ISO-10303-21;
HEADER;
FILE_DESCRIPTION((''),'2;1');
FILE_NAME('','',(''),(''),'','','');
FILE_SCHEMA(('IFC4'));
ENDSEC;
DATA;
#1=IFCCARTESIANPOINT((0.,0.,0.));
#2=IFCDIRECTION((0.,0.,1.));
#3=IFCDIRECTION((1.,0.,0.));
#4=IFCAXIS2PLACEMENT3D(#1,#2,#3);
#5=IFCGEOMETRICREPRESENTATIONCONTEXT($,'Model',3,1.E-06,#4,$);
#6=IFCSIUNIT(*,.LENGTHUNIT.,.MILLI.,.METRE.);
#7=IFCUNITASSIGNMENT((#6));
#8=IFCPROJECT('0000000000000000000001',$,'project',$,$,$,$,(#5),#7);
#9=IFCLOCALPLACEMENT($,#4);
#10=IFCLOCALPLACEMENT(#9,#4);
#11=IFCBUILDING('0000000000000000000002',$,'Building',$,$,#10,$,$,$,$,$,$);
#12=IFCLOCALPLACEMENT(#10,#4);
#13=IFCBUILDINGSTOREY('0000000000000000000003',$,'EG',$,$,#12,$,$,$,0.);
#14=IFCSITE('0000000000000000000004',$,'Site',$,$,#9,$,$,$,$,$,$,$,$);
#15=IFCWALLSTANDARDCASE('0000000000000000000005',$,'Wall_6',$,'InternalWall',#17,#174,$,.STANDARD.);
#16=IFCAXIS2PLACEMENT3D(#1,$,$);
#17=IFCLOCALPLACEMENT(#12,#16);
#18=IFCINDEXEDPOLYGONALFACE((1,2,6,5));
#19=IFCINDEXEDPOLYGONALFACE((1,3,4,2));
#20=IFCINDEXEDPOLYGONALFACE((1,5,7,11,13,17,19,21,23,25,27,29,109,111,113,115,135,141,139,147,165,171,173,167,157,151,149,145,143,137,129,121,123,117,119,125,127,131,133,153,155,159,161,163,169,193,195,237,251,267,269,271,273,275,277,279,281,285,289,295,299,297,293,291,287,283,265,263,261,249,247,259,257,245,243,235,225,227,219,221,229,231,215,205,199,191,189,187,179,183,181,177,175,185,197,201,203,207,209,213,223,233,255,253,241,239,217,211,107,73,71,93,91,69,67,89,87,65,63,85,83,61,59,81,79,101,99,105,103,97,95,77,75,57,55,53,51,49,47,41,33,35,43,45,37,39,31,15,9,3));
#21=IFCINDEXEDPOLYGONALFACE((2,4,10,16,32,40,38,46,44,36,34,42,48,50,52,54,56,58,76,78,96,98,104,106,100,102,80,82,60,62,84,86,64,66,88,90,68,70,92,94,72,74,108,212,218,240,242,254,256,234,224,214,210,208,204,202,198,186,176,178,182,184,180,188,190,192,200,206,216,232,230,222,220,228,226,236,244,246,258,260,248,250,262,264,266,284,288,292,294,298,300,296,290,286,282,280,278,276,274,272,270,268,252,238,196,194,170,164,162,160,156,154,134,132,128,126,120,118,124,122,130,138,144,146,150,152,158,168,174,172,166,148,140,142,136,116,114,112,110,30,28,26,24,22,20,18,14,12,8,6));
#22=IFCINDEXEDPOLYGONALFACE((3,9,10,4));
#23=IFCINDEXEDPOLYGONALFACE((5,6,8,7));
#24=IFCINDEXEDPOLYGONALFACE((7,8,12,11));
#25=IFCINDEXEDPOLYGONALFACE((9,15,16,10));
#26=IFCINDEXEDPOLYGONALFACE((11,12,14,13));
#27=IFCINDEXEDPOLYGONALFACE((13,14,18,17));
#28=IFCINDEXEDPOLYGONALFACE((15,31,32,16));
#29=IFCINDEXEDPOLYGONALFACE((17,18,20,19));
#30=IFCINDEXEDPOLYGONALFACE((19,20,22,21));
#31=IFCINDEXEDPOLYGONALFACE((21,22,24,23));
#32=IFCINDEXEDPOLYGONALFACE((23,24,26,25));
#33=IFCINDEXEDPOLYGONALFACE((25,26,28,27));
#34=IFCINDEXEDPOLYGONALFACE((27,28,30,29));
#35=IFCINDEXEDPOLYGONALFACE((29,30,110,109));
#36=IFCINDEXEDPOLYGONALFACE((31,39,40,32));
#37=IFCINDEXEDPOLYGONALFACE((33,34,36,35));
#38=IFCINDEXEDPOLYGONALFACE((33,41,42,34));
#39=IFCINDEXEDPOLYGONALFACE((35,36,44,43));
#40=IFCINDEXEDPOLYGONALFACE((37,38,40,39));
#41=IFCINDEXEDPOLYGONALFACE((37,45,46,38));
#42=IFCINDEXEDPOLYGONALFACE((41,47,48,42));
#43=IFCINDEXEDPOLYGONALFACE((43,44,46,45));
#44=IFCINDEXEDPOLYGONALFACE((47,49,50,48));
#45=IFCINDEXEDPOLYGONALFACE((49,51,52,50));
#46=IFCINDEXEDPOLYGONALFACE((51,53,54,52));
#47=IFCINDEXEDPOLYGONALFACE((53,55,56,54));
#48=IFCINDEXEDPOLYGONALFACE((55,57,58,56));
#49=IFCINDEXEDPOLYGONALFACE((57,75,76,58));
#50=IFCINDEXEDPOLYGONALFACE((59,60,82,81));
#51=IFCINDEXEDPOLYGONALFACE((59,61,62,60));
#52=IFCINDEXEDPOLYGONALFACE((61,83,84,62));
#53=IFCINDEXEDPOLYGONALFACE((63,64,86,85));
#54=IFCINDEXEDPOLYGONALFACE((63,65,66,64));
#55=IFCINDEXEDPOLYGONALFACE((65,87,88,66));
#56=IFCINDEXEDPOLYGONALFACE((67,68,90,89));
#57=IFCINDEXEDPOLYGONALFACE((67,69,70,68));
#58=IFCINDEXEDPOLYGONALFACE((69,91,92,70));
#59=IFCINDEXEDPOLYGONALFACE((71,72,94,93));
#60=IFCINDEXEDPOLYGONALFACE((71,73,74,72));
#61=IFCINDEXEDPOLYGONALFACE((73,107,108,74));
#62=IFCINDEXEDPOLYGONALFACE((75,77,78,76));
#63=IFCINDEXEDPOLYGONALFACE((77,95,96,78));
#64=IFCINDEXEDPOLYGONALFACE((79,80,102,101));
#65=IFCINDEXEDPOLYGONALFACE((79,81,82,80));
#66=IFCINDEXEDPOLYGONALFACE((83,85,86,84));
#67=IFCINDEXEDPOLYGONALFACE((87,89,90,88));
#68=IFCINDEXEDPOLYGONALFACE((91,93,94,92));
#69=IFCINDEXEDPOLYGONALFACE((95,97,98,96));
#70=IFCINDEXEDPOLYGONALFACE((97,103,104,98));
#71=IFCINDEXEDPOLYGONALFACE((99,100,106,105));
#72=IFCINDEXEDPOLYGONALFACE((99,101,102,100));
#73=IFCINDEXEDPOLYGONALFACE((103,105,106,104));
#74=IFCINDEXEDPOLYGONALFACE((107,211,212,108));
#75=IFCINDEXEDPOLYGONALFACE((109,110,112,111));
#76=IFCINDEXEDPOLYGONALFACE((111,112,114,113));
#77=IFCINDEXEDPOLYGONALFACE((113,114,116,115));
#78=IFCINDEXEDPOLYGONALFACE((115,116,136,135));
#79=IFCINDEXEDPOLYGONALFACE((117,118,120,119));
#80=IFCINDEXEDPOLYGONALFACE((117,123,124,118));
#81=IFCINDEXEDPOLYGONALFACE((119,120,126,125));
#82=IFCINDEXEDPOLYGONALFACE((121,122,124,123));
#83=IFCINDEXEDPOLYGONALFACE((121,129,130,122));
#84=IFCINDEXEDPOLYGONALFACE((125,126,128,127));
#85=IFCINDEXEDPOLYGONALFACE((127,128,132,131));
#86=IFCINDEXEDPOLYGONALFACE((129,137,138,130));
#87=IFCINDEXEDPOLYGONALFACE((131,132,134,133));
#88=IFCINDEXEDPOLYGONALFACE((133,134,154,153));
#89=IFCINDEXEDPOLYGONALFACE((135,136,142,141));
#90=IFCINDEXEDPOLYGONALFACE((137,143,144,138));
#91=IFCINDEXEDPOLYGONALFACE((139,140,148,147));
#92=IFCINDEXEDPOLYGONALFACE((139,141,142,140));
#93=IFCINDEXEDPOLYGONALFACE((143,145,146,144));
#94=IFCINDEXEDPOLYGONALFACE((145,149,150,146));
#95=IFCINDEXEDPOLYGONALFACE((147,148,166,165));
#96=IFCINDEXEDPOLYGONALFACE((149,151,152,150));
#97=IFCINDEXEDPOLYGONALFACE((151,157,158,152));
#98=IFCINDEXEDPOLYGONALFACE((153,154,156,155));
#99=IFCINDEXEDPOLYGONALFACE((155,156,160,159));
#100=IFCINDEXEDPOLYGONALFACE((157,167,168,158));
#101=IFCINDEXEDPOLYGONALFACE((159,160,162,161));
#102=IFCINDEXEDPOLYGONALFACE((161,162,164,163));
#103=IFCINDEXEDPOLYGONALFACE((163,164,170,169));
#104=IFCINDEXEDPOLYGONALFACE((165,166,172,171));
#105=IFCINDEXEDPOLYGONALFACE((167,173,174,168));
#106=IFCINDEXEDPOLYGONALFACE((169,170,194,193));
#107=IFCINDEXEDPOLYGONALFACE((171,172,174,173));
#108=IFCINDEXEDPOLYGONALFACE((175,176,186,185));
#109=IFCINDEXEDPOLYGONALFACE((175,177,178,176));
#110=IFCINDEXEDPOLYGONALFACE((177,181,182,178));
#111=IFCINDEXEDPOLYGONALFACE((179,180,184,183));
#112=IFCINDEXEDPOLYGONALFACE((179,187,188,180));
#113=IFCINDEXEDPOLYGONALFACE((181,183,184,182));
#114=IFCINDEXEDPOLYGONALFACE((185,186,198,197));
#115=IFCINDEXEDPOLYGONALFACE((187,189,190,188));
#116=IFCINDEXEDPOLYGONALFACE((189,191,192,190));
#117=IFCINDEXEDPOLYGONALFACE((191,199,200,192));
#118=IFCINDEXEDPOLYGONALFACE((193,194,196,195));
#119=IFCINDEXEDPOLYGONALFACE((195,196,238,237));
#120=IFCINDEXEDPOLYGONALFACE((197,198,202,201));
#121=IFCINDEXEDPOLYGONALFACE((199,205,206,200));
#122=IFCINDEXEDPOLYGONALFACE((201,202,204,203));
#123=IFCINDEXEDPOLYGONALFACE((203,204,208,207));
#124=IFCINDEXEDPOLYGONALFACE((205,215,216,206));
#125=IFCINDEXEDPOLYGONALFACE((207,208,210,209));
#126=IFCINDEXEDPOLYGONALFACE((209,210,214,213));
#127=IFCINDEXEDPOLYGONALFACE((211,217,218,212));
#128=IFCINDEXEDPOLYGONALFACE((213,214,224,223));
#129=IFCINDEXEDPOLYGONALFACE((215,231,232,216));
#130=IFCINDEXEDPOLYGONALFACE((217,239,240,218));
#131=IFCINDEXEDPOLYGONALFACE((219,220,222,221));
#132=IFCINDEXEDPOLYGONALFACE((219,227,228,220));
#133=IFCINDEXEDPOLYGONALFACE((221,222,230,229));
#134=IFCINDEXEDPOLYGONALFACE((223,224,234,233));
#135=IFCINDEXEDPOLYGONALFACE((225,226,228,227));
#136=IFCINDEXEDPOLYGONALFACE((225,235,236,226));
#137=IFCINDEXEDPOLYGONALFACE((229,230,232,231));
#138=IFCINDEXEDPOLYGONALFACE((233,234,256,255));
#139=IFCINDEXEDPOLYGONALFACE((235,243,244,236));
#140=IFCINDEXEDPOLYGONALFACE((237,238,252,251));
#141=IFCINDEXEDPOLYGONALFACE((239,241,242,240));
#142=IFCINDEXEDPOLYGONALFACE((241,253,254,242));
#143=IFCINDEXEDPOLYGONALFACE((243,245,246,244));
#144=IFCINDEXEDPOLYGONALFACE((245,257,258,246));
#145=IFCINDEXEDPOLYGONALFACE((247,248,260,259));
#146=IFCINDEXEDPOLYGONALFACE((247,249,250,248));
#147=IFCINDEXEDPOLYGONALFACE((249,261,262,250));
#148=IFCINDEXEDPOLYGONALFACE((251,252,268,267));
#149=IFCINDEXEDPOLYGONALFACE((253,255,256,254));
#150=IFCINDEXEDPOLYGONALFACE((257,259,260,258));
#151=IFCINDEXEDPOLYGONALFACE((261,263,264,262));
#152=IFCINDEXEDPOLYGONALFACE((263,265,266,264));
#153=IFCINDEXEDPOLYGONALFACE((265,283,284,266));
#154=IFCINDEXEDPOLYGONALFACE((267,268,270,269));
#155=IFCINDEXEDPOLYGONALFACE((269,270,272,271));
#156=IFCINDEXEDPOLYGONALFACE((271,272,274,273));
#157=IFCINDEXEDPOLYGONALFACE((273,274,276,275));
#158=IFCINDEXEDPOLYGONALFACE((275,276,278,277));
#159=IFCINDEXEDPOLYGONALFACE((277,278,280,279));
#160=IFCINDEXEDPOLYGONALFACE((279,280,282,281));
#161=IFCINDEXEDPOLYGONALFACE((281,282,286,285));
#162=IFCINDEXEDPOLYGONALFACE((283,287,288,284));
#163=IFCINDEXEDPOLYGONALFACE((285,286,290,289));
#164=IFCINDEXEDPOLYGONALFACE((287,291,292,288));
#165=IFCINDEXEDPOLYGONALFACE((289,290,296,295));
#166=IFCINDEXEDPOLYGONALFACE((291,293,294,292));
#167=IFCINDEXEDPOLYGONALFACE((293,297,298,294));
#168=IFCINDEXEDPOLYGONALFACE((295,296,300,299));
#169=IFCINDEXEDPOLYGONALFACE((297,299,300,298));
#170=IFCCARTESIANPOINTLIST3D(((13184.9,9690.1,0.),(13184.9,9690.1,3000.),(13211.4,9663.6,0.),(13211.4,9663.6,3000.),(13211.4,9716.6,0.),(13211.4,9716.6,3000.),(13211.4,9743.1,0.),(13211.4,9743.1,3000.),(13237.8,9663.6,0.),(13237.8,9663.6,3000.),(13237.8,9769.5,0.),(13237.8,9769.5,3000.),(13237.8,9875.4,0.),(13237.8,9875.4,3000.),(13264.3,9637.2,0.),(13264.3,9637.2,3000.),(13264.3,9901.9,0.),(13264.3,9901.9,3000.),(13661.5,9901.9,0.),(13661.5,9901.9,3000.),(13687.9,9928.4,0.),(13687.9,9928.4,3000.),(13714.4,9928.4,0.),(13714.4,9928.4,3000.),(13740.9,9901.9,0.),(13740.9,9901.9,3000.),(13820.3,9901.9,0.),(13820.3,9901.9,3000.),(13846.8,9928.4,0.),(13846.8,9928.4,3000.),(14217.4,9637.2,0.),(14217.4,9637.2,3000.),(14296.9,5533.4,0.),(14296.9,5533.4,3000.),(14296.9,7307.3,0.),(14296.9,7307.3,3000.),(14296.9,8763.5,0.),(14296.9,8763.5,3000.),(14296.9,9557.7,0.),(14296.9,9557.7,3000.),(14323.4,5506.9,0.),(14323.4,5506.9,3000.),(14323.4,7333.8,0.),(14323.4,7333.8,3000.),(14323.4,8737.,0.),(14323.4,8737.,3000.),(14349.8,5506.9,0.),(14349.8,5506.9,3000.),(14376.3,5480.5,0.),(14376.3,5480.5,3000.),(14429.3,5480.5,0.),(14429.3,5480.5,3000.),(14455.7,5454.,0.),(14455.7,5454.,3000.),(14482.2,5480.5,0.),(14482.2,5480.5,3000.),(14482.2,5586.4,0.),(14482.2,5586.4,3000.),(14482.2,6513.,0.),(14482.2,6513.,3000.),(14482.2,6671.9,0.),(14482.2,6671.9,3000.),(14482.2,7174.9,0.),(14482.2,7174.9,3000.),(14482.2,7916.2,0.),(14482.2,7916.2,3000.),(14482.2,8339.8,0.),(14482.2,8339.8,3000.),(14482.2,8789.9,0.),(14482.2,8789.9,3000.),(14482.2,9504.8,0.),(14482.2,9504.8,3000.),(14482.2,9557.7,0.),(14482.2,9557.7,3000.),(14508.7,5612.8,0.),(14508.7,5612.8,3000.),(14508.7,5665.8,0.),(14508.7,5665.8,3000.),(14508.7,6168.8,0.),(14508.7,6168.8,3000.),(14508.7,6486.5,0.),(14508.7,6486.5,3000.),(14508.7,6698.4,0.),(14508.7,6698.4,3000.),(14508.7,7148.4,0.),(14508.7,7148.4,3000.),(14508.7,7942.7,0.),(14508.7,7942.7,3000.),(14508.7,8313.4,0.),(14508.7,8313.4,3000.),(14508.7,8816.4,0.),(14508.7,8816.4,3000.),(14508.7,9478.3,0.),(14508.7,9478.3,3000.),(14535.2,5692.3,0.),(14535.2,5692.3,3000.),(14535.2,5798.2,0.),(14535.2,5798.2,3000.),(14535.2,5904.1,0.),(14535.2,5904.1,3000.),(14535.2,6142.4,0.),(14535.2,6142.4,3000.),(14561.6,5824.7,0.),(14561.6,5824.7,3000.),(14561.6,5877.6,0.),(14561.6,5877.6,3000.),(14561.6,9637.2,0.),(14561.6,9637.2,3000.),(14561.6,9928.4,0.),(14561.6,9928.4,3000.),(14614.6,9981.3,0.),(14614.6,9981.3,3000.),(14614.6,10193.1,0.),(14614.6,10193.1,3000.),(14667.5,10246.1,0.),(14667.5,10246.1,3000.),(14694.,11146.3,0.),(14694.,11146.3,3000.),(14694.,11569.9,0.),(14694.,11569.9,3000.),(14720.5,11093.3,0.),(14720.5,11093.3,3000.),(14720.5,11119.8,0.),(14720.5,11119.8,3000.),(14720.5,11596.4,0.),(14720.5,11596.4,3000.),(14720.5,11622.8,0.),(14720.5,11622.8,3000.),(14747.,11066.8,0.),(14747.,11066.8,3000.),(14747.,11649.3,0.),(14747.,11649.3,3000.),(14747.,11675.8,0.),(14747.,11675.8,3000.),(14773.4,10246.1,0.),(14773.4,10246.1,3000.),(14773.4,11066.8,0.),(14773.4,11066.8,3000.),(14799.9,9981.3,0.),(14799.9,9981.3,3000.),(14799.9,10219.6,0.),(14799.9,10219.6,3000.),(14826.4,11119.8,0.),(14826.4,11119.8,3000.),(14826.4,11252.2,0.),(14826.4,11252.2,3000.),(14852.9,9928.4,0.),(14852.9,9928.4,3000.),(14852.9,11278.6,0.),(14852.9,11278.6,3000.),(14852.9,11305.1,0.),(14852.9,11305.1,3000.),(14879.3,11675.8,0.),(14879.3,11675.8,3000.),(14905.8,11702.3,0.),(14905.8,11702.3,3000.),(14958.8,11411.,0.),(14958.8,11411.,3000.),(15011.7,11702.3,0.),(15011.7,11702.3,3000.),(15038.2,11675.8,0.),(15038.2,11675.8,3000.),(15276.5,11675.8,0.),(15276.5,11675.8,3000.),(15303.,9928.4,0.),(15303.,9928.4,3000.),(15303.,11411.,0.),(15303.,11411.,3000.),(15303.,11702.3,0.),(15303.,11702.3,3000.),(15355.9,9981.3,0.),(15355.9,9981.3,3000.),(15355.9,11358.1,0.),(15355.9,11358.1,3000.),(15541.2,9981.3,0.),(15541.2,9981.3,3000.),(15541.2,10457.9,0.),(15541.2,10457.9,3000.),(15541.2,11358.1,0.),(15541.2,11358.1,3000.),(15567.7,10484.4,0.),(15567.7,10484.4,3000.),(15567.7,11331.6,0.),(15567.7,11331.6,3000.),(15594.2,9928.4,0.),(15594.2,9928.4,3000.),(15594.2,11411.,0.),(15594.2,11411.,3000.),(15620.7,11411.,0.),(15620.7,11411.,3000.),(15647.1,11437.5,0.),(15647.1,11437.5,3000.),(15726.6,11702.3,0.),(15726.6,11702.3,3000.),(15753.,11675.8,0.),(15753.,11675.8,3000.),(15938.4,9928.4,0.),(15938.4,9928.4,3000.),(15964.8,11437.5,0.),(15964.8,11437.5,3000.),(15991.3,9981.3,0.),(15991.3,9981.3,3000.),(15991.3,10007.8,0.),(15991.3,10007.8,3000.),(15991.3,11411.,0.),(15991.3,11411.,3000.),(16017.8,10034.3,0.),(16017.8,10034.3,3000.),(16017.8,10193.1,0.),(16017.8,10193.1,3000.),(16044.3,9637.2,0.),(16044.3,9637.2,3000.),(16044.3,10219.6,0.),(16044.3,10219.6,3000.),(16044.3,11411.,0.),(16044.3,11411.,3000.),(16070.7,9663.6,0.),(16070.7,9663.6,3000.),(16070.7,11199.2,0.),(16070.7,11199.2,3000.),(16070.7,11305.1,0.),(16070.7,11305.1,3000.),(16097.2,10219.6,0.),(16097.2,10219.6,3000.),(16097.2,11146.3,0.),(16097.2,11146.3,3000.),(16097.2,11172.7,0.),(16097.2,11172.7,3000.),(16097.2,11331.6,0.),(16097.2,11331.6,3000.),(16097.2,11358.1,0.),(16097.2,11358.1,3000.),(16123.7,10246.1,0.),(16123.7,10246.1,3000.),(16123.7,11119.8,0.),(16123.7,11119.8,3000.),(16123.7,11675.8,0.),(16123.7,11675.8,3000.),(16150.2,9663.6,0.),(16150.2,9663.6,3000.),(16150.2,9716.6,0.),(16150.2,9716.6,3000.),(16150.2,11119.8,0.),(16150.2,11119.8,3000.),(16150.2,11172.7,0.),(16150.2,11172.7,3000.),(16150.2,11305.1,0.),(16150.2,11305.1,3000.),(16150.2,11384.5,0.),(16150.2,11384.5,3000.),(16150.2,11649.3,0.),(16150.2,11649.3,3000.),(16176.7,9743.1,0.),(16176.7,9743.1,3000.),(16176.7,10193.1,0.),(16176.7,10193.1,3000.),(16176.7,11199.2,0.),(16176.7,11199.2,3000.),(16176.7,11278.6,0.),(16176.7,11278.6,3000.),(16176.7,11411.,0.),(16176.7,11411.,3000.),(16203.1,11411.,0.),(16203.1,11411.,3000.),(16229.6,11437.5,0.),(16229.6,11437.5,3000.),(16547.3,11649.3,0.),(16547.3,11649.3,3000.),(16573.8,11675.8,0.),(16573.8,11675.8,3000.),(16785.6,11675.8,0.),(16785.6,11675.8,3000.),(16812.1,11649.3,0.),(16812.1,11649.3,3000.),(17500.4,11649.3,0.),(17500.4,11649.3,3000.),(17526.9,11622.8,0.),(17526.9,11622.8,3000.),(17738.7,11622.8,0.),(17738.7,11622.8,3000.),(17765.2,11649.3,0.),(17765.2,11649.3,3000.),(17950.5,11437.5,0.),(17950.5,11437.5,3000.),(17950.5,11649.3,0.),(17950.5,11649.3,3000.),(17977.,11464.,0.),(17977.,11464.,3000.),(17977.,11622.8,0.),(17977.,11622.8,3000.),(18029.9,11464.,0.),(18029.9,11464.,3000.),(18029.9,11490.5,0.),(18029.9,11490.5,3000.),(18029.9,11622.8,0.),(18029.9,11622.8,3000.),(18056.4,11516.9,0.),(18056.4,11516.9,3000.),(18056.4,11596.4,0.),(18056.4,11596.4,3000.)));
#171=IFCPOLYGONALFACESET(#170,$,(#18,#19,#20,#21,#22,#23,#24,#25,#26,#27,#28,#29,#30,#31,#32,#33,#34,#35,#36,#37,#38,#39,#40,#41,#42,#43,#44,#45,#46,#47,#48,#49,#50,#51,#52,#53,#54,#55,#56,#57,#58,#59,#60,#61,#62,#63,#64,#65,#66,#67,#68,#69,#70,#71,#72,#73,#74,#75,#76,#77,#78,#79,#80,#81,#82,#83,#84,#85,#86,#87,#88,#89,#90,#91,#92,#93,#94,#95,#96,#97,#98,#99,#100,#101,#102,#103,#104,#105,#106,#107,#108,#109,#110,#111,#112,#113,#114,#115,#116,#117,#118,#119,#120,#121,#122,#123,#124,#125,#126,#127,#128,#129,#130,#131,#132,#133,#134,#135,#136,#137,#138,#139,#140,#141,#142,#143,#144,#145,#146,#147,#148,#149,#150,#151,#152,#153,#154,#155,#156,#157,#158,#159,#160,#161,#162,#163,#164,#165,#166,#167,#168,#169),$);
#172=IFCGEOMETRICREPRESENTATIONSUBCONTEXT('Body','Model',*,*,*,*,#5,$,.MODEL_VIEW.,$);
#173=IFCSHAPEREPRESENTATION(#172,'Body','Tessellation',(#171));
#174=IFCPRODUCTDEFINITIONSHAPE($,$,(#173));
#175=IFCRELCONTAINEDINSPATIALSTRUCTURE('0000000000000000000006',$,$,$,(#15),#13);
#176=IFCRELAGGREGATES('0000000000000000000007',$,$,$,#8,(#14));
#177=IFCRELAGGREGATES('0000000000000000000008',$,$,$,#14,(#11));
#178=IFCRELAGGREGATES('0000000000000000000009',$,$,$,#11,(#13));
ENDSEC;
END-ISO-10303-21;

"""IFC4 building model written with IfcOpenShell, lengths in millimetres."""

from ifc_helpers import new_model, si_unit, origin_with_axes, place, context, subcontext, project, spatial, polyline, outline, extrude, element, save


model = new_model("IFC4")

# Units and contexts
model_context = context("Model", 3, precision=1e-06, world=origin_with_axes())
body_context = subcontext(model_context, "Body", "Model", "MODEL_VIEW")
ifc_project = project(units=[si_unit("LENGTHUNIT", "METRE", prefix="MILLI")], contexts=[model_context])

# Site, building, storey
site_placement = place(None, origin_with_axes())
site = spatial("IfcSite", under=ifc_project, at=site_placement, Name="Site")
building_placement = place(site_placement, origin_with_axes())
building = spatial("IfcBuilding", under=site, at=building_placement, Name="Building")
storey_placement = place(building_placement, origin_with_axes())
storey = spatial("IfcBuildingStorey", under=building, at=storey_placement, Name="EG", Elevation=0.0)

# Wall
wall_1_placement = place(storey_placement, origin_with_axes())
element("IfcWallStandardCase", 1, at=wall_1_placement, inside=storey, Name="Wall_6", ObjectType="InternalWall", PredefinedType="STANDARD", context=body_context, shape_type="SweptSolid", body=[
    extrude(outline(polyline([(14455.7, 5454.0, 0.0), (14429.3, 5480.5, 0.0), (14376.3, 5480.5, 0.0), (14349.8, 5506.9, 0.0), (14323.4, 5506.9, 0.0), (14296.9, 5533.4, 0.0), (14296.9, 7307.3, 0.0), (14323.4, 7333.8, 0.0), (14323.4, 8737.0, 0.0), (14296.9, 8763.5, 0.0), (14296.9, 9557.7, 0.0), (14217.4, 9637.2, 0.0), (13264.3, 9637.2, 0.0), (13237.8, 9663.6, 0.0), (13211.4, 9663.6, 0.0), (13184.9, 9690.1, 0.0), (13211.4, 9716.6, 0.0), (13211.4, 9743.1, 0.0), (13237.8, 9769.5, 0.0), (13237.8, 9875.4, 0.0), (13264.3, 9901.9, 0.0), (13661.5, 9901.9, 0.0), (13687.9, 9928.4, 0.0), (13714.4, 9928.4, 0.0), (13740.9, 9901.9, 0.0), (13820.3, 9901.9, 0.0), (13846.8, 9928.4, 0.0), (14561.6, 9928.4, 0.0), (14614.6, 9981.3, 0.0), (14614.6, 10193.1, 0.0), (14667.5, 10246.1, 0.0), (14773.4, 10246.1, 0.0), (14799.9, 10219.6, 0.0), (14799.9, 9981.3, 0.0), (14852.9, 9928.4, 0.0), (15303.0, 9928.4, 0.0), (15355.9, 9981.3, 0.0), (15355.9, 11358.1, 0.0), (15303.0, 11411.0, 0.0), (14958.8, 11411.0, 0.0), (14852.9, 11305.1, 0.0), (14852.9, 11278.6, 0.0), (14826.4, 11252.2, 0.0), (14826.4, 11119.8, 0.0), (14773.4, 11066.8, 0.0), (14747.0, 11066.8, 0.0), (14720.5, 11093.3, 0.0), (14720.5, 11119.8, 0.0), (14694.0, 11146.3, 0.0), (14694.0, 11569.9, 0.0), (14720.5, 11596.4, 0.0), (14720.5, 11622.8, 0.0), (14747.0, 11649.3, 0.0), (14747.0, 11675.8, 0.0), (14879.3, 11675.8, 0.0), (14905.8, 11702.3, 0.0), (15011.7, 11702.3, 0.0), (15038.2, 11675.8, 0.0), (15276.5, 11675.8, 0.0), (15303.0, 11702.3, 0.0), (15726.6, 11702.3, 0.0), (15753.0, 11675.8, 0.0), (16123.7, 11675.8, 0.0), (16150.2, 11649.3, 0.0), (16547.3, 11649.3, 0.0), (16573.8, 11675.8, 0.0), (16785.6, 11675.8, 0.0), (16812.1, 11649.3, 0.0), (17500.4, 11649.3, 0.0), (17526.9, 11622.8, 0.0), (17738.7, 11622.8, 0.0), (17765.2, 11649.3, 0.0), (17950.5, 11649.3, 0.0), (17977.0, 11622.8, 0.0), (18029.9, 11622.8, 0.0), (18056.4, 11596.4, 0.0), (18056.4, 11516.9, 0.0), (18029.9, 11490.5, 0.0), (18029.9, 11464.0, 0.0), (17977.0, 11464.0, 0.0), (17950.5, 11437.5, 0.0), (16229.6, 11437.5, 0.0), (16203.1, 11411.0, 0.0), (16176.7, 11411.0, 0.0), (16150.2, 11384.5, 0.0), (16150.2, 11305.1, 0.0), (16176.7, 11278.6, 0.0), (16176.7, 11199.2, 0.0), (16150.2, 11172.7, 0.0), (16150.2, 11119.8, 0.0), (16123.7, 11119.8, 0.0), (16097.2, 11146.3, 0.0), (16097.2, 11172.7, 0.0), (16070.7, 11199.2, 0.0), (16070.7, 11305.1, 0.0), (16097.2, 11331.6, 0.0), (16097.2, 11358.1, 0.0), (16044.3, 11411.0, 0.0), (15991.3, 11411.0, 0.0), (15964.8, 11437.5, 0.0), (15647.1, 11437.5, 0.0), (15620.7, 11411.0, 0.0), (15594.2, 11411.0, 0.0), (15541.2, 11358.1, 0.0), (15567.7, 11331.6, 0.0), (15567.7, 10484.4, 0.0), (15541.2, 10457.9, 0.0), (15541.2, 9981.3, 0.0), (15594.2, 9928.4, 0.0), (15938.4, 9928.4, 0.0), (15991.3, 9981.3, 0.0), (15991.3, 10007.8, 0.0), (16017.8, 10034.3, 0.0), (16017.8, 10193.1, 0.0), (16044.3, 10219.6, 0.0), (16097.2, 10219.6, 0.0), (16123.7, 10246.1, 0.0), (16176.7, 10193.1, 0.0), (16176.7, 9743.1, 0.0), (16150.2, 9716.6, 0.0), (16150.2, 9663.6, 0.0), (16070.7, 9663.6, 0.0), (16044.3, 9637.2, 0.0), (14561.6, 9637.2, 0.0), (14482.2, 9557.7, 0.0), (14482.2, 9504.8, 0.0), (14508.7, 9478.3, 0.0), (14508.7, 8816.4, 0.0), (14482.2, 8789.9, 0.0), (14482.2, 8339.8, 0.0), (14508.7, 8313.4, 0.0), (14508.7, 7942.7, 0.0), (14482.2, 7916.2, 0.0), (14482.2, 7174.9, 0.0), (14508.7, 7148.4, 0.0), (14508.7, 6698.4, 0.0), (14482.2, 6671.9, 0.0), (14482.2, 6513.0, 0.0), (14508.7, 6486.5, 0.0), (14508.7, 6168.8, 0.0), (14535.2, 6142.4, 0.0), (14535.2, 5904.1, 0.0), (14561.6, 5877.6, 0.0), (14561.6, 5824.7, 0.0), (14535.2, 5798.2, 0.0), (14535.2, 5692.3, 0.0), (14508.7, 5665.8, 0.0), (14508.7, 5612.8, 0.0), (14482.2, 5586.4, 0.0), (14482.2, 5480.5, 0.0), (14455.7, 5454.0, 0.0)])), origin_with_axes(), (0.0, 0.0, 1.0), 3000.0),
])

save(model, "model.ifc")
